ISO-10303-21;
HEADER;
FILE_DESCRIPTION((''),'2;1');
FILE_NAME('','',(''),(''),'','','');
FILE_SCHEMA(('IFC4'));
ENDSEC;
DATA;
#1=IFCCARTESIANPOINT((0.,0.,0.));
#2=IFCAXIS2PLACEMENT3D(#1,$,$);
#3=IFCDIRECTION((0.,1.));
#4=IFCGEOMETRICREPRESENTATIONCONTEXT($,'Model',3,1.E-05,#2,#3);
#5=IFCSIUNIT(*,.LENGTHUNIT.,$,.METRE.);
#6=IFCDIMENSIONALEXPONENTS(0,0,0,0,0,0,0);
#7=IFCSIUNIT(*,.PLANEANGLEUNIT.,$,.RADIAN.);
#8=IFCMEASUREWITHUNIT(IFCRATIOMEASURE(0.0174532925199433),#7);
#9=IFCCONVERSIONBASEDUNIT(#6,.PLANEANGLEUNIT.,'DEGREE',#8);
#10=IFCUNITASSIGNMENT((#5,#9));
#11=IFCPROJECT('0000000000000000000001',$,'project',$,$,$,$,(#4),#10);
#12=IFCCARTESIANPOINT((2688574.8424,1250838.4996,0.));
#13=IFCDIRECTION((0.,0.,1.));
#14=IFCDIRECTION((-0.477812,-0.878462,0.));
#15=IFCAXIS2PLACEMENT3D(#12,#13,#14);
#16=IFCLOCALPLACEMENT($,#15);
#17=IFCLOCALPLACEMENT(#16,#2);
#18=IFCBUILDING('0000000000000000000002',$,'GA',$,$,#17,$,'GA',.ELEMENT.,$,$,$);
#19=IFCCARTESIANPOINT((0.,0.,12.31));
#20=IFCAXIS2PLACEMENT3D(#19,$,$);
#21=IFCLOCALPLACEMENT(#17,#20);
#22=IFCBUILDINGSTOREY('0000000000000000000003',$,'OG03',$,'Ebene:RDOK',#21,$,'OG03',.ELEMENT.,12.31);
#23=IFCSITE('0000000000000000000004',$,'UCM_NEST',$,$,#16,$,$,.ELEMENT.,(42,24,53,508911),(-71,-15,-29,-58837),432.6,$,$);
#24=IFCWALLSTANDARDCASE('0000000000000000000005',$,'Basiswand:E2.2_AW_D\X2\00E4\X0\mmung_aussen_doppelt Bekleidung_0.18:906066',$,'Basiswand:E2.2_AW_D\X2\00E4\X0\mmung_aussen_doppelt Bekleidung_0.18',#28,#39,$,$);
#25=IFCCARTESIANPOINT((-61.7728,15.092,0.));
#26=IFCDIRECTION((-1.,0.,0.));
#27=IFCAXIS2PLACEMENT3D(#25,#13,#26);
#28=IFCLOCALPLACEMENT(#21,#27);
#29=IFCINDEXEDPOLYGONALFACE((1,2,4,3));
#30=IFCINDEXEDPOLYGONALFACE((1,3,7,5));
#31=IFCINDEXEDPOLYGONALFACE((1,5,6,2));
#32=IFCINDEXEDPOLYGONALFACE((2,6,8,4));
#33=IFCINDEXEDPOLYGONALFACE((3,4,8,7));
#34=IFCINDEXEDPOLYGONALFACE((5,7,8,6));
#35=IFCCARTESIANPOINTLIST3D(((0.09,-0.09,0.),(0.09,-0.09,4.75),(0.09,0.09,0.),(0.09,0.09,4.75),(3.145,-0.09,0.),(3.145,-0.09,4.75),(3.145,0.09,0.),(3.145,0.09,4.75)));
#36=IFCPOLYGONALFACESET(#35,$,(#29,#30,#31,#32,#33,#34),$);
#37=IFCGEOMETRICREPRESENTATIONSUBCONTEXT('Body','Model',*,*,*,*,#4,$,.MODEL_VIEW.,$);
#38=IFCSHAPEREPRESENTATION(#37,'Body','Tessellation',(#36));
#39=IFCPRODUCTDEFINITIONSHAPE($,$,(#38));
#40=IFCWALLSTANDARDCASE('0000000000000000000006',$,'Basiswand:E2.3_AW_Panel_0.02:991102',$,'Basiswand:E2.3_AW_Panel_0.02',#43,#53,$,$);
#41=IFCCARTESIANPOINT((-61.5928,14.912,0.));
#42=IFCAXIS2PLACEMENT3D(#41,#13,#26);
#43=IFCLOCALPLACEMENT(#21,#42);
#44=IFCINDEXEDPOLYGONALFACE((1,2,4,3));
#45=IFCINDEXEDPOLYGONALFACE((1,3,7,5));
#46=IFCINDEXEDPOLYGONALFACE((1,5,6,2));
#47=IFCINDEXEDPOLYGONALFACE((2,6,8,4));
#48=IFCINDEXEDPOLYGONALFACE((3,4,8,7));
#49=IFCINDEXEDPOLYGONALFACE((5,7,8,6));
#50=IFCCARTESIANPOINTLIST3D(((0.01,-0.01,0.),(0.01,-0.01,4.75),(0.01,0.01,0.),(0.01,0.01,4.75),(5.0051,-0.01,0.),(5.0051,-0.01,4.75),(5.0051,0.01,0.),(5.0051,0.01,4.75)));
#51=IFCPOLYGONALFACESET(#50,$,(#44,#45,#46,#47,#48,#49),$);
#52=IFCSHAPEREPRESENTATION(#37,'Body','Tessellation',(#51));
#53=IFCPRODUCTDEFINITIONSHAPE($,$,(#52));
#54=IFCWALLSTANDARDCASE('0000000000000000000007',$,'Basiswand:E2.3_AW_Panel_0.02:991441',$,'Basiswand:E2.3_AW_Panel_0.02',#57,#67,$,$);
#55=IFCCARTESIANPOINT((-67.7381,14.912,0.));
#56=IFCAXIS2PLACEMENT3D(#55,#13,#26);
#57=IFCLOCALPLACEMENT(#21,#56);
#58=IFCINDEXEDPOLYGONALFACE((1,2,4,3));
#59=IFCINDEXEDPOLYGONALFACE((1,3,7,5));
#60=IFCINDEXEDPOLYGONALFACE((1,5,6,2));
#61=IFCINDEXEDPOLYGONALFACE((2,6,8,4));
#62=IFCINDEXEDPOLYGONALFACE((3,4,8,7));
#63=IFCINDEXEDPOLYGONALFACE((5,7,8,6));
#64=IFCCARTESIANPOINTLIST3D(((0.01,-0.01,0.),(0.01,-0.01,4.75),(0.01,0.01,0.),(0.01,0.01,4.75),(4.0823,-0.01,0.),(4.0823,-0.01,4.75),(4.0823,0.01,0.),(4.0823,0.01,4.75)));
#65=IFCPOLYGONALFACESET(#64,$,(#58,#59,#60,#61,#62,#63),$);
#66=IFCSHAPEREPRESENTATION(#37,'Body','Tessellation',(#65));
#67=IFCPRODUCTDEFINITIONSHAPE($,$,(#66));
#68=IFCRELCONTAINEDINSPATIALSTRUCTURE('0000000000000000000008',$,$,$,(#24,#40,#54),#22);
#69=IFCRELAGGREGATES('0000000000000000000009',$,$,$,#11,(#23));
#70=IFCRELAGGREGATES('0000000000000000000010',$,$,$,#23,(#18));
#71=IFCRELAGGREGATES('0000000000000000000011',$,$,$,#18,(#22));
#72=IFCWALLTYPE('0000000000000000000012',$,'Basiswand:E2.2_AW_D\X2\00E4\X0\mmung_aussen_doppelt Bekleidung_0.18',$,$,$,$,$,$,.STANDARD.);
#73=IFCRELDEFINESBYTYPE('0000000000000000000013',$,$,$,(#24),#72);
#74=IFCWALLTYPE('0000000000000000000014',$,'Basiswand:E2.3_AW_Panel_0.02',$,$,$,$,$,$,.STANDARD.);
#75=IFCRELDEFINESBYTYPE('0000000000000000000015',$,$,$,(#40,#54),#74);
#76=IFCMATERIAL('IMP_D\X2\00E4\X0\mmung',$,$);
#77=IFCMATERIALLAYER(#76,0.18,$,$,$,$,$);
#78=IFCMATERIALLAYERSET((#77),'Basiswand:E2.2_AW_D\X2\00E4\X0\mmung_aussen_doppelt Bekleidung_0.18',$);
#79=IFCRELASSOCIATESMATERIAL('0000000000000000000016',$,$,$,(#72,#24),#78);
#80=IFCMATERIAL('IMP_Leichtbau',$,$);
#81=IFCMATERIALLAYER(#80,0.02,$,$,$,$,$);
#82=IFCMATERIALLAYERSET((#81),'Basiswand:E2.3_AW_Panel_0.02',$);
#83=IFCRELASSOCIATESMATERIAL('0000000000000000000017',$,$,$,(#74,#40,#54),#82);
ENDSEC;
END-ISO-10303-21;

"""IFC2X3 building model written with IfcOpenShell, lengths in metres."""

from ifc_helpers import new_model, entity, si_unit, converted_unit, direction, frame, frame_2d, origin, place, context, subcontext, project, spatial, rectangle, extrude, material, layer, layer_set, layer_usage, type_object, element, save


model = new_model("IFC2X3")

# Units and contexts
model_context = context("Model", 3, precision=1e-05, world=origin(), true_north=direction((0.0, 1.0)))
body_context = subcontext(model_context, "Body", "Model", "MODEL_VIEW")
ifc_project = project(units=[si_unit("LENGTHUNIT", "METRE"), converted_unit("PLANEANGLEUNIT", "DEGREE", entity("IfcRatioMeasure", 0.0174532925199433), si_unit("PLANEANGLEUNIT", "RADIAN"), dimensions=[0, 0, 0, 0, 0, 0, 0])], contexts=[model_context])

# Site, building, storey
site_placement = place(None, frame((2688574.8424, 1250838.4996, 0.0), z_axis=(0.0, 0.0, 1.0), x_axis=(-0.477812, -0.878462, 0.0)))
site = spatial("IfcSite", under=ifc_project, at=site_placement, Name="UCM_NEST", CompositionType="ELEMENT", RefLatitude=(42, 24, 53, 508911), RefLongitude=(-71, -15, -29, -58837), RefElevation=432.6)
building_placement = place(site_placement, origin())
building = spatial("IfcBuilding", under=site, at=building_placement, Name="GA", LongName="GA", CompositionType="ELEMENT")
storey_placement = place(building_placement, frame((0.0, 0.0, 12.31)))
storey = spatial("IfcBuildingStorey", under=building, at=storey_placement, Name="OG03", ObjectType="Ebene:RDOK", LongName="OG03", CompositionType="ELEMENT", Elevation=12.31)

# Wall
ifc_material_1 = material(Name="IMP_Dämmung")
ifc_layer_1 = layer(ifc_material_1, 0.18)
ifc_layer_set_1 = layer_set([ifc_layer_1], Name="Basiswand:E2.2_AW_Dämmung_aussen_doppelt Bekleidung_0.18")
ifc_layer_usage_1 = layer_usage(ifc_layer_set_1, "AXIS2", "NEGATIVE", 0.09)
wall_type_1 = type_object("IfcWallType", Name="Basiswand:E2.2_AW_Dämmung_aussen_doppelt Bekleidung_0.18", PredefinedType="STANDARD", material=ifc_layer_set_1)
wall_1_placement = place(storey_placement, frame((-61.7728, 15.092, 0.0), z_axis=(0.0, 0.0, 1.0), x_axis=(-1.0, 0.0, 0.0)))
element("IfcWallStandardCase", 1, at=wall_1_placement, inside=storey, type_object=wall_type_1, material=ifc_layer_usage_1, Name="Basiswand:E2.2_AW_Dämmung_aussen_doppelt Bekleidung_0.18:906066", ObjectType="Basiswand:E2.2_AW_Dämmung_aussen_doppelt Bekleidung_0.18", context=body_context, shape_type="SweptSolid", body=[
    extrude(rectangle(XDim=3.055, YDim=0.18, at=frame_2d((1.6175, 0.0), x_axis=(-1.0, 0.0))), origin(), (0.0, 0.0, 1.0), 4.75),
])

# Walls
ifc_material_2 = material(Name="IMP_Leichtbau")
ifc_layer_2 = layer(ifc_material_2, 0.02)
ifc_layer_set_2 = layer_set([ifc_layer_2], Name="Basiswand:E2.3_AW_Panel_0.02")
ifc_layer_usage_2 = layer_usage(ifc_layer_set_2, "AXIS2", "NEGATIVE", 0.01)
wall_type_2 = type_object("IfcWallType", Name="Basiswand:E2.3_AW_Panel_0.02", PredefinedType="STANDARD", material=ifc_layer_set_2)
wall_2_placement = place(storey_placement, frame((-61.5928, 14.912, 0.0), z_axis=(0.0, 0.0, 1.0), x_axis=(-1.0, 0.0, 0.0)))
element("IfcWallStandardCase", 2, at=wall_2_placement, inside=storey, type_object=wall_type_2, material=ifc_layer_usage_2, Name="Basiswand:E2.3_AW_Panel_0.02:991102", ObjectType="Basiswand:E2.3_AW_Panel_0.02", context=body_context, shape_type="SweptSolid", body=[
    extrude(rectangle(XDim=4.9951, YDim=0.02, at=frame_2d((2.5076, 0.0), x_axis=(-1.0, 0.0))), origin(), (0.0, 0.0, 1.0), 4.75),
])
ifc_layer_usage_3 = layer_usage(ifc_layer_set_2, "AXIS2", "NEGATIVE", 0.01)
wall_3_placement = place(storey_placement, frame((-67.7381, 14.912, 0.0), z_axis=(0.0, 0.0, 1.0), x_axis=(-1.0, 0.0, 0.0)))
element("IfcWallStandardCase", 3, at=wall_3_placement, inside=storey, type_object=wall_type_2, material=ifc_layer_usage_3, Name="Basiswand:E2.3_AW_Panel_0.02:991441", ObjectType="Basiswand:E2.3_AW_Panel_0.02", context=body_context, shape_type="SweptSolid", body=[
    extrude(rectangle(XDim=4.0723, YDim=0.02, at=frame_2d((2.0462, 0.0), x_axis=(-1.0, 0.0))), origin(), (0.0, 0.0, 1.0), 4.75),
])

save(model, "model.ifc")
